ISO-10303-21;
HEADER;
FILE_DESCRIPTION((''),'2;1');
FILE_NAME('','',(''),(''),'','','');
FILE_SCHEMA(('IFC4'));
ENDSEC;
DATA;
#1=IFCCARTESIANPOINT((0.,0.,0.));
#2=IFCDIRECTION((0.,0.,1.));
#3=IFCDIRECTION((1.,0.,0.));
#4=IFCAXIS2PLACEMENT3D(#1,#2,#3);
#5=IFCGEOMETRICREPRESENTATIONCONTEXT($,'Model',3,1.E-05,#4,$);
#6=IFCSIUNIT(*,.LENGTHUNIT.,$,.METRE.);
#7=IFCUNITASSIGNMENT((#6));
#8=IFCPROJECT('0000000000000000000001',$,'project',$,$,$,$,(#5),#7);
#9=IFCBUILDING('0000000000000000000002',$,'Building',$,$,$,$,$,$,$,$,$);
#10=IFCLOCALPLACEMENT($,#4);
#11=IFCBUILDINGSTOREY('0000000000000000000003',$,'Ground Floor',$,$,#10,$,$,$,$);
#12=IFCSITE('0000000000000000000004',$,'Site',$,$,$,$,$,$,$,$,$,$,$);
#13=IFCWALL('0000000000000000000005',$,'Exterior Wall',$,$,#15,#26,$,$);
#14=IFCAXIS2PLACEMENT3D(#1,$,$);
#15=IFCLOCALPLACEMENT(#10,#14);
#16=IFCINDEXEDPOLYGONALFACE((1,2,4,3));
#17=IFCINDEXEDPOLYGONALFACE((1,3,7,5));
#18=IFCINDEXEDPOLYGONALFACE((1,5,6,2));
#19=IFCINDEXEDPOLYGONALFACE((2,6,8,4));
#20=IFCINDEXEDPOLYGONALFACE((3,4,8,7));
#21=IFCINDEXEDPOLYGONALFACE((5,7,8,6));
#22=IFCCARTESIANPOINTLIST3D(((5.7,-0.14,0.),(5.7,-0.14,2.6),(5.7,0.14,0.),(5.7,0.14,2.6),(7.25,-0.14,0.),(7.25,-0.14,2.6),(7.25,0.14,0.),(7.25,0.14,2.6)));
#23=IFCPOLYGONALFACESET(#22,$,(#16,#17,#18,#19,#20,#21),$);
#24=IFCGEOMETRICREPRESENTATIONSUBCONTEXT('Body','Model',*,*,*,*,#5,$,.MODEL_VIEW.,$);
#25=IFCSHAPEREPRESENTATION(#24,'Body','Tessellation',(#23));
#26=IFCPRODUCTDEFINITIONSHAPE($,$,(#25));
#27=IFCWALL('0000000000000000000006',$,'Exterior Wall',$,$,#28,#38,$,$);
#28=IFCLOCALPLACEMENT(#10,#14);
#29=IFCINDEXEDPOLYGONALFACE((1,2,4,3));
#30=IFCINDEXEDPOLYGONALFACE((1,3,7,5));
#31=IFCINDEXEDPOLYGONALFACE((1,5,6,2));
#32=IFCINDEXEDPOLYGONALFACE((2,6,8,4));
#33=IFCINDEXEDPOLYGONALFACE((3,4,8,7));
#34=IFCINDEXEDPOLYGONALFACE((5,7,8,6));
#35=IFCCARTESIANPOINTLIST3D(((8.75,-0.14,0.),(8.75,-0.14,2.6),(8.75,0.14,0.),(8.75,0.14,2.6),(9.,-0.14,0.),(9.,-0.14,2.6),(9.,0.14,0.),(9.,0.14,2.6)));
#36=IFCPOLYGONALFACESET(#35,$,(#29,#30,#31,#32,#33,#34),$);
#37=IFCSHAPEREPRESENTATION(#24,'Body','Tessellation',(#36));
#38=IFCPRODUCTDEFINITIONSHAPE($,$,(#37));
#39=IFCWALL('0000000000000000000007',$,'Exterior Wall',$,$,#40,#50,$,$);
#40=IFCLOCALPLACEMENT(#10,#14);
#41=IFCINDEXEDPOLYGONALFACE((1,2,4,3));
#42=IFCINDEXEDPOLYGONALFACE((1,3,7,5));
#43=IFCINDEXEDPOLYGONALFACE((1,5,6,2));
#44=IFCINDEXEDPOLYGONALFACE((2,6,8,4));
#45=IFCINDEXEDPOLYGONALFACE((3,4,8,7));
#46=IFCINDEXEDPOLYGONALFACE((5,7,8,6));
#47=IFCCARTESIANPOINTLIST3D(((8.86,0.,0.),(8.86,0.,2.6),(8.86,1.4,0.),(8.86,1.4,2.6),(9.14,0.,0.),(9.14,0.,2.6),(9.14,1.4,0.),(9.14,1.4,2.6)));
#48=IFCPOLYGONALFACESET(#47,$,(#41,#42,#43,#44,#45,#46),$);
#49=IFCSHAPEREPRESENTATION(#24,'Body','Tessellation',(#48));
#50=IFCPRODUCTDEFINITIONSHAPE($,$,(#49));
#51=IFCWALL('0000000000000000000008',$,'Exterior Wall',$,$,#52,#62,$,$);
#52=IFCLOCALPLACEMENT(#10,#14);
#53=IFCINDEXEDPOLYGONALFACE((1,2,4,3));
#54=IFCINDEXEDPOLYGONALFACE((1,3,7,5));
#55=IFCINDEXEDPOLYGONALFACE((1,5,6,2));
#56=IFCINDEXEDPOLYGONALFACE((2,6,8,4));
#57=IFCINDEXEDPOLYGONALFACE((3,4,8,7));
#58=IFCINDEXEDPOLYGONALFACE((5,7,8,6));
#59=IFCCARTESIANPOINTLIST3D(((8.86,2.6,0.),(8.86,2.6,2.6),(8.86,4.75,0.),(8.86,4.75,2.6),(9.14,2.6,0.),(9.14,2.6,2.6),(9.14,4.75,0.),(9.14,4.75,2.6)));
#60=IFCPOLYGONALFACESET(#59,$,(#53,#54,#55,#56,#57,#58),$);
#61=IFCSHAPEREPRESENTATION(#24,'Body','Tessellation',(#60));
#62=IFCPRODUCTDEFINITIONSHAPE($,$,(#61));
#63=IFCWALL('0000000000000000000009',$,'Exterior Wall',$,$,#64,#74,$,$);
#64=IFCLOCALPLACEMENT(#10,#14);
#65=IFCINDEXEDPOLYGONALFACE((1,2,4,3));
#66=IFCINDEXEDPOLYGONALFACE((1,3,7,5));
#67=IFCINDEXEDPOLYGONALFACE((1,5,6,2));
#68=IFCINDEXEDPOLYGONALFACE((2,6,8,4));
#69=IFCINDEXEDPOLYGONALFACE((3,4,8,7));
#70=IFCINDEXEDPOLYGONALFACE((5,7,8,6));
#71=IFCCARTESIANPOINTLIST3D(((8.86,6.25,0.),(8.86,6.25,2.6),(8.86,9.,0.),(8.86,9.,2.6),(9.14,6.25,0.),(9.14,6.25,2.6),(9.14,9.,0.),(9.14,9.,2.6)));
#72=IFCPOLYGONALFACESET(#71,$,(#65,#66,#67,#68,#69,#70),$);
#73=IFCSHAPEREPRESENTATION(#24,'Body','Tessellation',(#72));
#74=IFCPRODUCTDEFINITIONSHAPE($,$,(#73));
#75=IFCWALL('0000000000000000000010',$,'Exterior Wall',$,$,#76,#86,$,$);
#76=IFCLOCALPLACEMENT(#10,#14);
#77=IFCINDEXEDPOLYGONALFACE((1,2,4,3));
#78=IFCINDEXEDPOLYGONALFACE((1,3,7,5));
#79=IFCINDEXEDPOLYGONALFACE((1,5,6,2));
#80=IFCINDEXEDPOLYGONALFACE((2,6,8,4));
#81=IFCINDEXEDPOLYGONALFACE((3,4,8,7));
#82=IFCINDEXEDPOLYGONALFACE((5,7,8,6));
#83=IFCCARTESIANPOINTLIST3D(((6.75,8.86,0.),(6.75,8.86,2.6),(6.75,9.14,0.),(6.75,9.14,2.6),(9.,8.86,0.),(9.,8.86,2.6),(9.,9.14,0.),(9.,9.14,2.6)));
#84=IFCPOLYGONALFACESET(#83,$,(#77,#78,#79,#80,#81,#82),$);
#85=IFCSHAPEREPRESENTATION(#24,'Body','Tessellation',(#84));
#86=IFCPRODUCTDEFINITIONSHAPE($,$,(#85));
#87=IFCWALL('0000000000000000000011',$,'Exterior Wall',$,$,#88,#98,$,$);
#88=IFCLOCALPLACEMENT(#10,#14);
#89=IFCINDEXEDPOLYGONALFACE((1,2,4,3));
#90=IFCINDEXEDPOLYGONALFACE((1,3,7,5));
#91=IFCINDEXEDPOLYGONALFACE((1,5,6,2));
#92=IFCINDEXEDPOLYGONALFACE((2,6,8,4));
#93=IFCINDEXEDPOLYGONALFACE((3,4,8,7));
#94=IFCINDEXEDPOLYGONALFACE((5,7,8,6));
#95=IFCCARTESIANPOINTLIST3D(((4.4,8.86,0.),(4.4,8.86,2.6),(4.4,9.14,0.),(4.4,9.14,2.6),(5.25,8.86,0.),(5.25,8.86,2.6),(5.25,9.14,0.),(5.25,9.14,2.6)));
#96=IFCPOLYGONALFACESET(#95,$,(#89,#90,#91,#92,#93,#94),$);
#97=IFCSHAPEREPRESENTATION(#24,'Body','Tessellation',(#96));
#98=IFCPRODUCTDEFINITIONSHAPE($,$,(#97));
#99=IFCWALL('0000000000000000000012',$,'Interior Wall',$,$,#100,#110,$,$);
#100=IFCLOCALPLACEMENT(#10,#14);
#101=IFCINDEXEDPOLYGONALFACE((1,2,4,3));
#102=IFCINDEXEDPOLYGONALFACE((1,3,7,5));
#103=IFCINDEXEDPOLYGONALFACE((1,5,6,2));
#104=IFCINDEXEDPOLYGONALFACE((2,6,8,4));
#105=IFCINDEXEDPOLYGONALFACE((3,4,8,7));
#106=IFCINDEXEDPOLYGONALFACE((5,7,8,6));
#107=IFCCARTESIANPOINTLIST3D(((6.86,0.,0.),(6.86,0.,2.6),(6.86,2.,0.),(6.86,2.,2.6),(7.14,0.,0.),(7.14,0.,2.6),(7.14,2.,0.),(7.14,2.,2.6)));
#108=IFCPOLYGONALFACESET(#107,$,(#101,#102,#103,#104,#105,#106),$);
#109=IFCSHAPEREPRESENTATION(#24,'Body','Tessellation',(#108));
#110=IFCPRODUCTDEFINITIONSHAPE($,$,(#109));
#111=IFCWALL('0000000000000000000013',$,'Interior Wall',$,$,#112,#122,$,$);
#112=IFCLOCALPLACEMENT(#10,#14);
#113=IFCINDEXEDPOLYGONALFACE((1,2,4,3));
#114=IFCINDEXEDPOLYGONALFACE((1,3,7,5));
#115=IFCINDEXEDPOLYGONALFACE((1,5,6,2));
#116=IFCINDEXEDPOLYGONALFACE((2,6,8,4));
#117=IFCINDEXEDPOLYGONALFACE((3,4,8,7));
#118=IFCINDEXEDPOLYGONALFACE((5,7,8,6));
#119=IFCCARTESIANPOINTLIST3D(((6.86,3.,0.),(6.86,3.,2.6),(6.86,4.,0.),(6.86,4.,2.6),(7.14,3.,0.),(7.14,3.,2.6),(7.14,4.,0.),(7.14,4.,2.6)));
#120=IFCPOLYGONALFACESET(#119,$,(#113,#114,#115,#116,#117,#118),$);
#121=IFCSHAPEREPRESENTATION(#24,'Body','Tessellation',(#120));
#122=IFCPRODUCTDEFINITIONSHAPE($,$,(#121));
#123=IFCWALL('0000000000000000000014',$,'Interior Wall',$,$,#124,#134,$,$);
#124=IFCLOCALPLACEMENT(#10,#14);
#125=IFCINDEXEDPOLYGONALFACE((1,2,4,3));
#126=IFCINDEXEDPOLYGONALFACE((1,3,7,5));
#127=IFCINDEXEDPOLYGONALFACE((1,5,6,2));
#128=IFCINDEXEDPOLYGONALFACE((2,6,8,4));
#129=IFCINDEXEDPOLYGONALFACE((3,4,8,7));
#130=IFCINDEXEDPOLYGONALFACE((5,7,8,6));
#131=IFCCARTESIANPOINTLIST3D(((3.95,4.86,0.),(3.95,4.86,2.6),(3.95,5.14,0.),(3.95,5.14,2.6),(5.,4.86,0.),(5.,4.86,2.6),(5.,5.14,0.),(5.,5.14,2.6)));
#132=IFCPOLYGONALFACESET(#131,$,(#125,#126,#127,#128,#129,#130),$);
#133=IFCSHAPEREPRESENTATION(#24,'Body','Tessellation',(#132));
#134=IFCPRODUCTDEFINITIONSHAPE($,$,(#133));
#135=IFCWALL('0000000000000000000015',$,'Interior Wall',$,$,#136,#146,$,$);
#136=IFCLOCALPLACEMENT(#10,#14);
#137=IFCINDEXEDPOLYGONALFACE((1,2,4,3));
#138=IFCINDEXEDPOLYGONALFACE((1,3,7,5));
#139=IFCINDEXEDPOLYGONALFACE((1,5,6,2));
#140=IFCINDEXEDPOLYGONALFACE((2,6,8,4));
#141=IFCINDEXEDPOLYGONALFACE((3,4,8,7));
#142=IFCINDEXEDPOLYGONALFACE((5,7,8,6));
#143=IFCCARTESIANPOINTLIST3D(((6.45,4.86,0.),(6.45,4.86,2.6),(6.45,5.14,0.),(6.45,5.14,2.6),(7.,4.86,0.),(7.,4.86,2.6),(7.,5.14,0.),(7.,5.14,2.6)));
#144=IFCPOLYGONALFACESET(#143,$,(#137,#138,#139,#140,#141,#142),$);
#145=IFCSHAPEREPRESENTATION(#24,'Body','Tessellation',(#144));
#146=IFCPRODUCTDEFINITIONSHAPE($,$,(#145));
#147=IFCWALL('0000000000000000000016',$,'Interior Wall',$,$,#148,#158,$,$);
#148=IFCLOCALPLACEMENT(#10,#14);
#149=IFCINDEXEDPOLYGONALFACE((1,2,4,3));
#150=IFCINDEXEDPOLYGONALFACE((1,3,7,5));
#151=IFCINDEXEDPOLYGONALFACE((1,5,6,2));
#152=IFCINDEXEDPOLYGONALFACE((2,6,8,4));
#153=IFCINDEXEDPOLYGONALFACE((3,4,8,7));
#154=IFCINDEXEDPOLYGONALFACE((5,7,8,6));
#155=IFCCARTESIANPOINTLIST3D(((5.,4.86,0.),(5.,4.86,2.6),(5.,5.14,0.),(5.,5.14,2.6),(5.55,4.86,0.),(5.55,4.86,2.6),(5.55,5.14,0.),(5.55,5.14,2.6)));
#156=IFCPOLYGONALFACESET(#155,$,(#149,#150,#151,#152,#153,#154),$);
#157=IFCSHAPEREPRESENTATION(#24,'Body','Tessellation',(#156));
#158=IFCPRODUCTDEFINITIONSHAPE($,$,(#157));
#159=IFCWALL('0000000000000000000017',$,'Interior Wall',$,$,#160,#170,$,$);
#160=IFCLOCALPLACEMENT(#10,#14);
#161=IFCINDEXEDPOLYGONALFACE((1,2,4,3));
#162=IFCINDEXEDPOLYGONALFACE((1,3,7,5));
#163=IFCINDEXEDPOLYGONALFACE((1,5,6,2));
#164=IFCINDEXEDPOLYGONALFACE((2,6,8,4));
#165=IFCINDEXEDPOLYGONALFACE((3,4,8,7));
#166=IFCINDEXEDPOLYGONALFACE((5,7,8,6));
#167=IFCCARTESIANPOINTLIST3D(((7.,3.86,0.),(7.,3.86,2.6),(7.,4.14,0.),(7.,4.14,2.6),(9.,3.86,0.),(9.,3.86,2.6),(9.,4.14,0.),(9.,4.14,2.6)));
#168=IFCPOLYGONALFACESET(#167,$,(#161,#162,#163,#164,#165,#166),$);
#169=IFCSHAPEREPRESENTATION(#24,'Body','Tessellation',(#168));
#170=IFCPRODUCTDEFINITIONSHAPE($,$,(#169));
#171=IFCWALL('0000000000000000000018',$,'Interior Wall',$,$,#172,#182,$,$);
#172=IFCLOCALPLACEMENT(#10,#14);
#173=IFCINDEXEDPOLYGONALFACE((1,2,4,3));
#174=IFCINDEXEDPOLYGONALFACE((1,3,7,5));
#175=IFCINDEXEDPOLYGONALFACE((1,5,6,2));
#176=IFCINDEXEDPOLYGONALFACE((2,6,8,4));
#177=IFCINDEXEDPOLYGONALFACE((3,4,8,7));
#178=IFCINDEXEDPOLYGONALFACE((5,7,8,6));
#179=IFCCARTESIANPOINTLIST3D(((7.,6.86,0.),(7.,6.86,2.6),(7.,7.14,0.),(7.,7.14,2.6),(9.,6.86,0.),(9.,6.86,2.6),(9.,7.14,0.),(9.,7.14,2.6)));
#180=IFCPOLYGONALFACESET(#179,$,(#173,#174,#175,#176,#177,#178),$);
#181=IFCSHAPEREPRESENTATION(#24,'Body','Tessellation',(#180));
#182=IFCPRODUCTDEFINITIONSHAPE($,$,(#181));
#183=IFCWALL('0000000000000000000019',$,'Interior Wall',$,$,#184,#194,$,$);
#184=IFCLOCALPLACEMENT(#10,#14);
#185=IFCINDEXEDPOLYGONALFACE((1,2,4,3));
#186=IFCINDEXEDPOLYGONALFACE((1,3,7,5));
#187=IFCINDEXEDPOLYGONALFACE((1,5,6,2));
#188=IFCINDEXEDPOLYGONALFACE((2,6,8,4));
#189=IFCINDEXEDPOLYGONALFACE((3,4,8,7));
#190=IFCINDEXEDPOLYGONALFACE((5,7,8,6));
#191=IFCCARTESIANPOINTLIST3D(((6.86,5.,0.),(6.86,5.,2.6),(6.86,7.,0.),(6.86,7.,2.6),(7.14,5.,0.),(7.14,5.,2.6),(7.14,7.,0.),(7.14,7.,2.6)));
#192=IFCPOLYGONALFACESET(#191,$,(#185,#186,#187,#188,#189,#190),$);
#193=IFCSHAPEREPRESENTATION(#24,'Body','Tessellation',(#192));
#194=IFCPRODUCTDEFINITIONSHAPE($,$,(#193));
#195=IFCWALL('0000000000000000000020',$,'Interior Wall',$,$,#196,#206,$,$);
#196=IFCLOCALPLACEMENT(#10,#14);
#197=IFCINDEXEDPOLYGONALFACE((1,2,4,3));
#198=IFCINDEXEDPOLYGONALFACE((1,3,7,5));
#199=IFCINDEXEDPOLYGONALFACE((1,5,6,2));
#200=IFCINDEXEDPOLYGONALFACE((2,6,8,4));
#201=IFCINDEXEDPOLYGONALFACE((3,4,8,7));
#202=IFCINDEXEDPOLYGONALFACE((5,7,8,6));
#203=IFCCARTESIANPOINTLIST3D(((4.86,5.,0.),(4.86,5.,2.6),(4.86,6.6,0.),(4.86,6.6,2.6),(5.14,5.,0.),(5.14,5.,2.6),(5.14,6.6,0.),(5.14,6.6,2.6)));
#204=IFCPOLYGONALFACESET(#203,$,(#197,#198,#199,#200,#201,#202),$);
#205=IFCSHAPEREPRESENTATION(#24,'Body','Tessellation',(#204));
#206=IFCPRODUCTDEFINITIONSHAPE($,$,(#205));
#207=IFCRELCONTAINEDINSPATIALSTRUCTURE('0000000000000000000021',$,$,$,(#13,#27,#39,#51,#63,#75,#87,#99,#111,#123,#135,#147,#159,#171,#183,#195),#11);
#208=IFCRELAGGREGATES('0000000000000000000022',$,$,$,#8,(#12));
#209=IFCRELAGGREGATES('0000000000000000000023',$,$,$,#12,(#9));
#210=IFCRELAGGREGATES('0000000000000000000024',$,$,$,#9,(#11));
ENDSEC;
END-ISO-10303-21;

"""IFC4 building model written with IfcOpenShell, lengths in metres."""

from ifc_helpers import new_model, si_unit, frame, origin_with_axes, place, context, subcontext, project, spatial, indexed_curve, outline, extrude, element, save


model = new_model("IFC4")

# Units and contexts
model_context = context("Model", 3, precision=1e-05, world=origin_with_axes())
body_context = subcontext(model_context, "Body", "Model", "MODEL_VIEW")
ifc_project = project(units=[si_unit("LENGTHUNIT", "METRE")], contexts=[model_context])

# Site, building, storey
site = spatial("IfcSite", under=ifc_project, Name="Site")
building = spatial("IfcBuilding", under=site, Name="Building")
storey_placement = place(None, origin_with_axes())
storey = spatial("IfcBuildingStorey", under=building, at=storey_placement, Name="Ground Floor")

# Walls
wall_1_placement = place(storey_placement, frame((5.7, 0.0, 0.0), z_axis=(0.0, 0.0, 1.0), x_axis=(1.0, 0.0, 0.0)))
element("IfcWall", 1, at=wall_1_placement, inside=storey, Name="Exterior Wall", context=body_context, shape_type="SweptSolid", body=[
    extrude(outline(indexed_curve([(0.0, 0.0), (0.0, 0.28), (1.55, 0.28), (1.55, 0.0), (0.0, 0.0)], self_intersect=False)), frame((0.0, -0.14, 0.0), z_axis=(0.0, 0.0, 1.0), x_axis=(1.0, 0.0, 0.0)), (0.0, 0.0, 1.0), 2.6),
])
wall_2_placement = place(storey_placement, frame((8.75, 0.0, 0.0), z_axis=(0.0, 0.0, 1.0), x_axis=(1.0, 0.0, 0.0)))
element("IfcWall", 2, at=wall_2_placement, inside=storey, Name="Exterior Wall", context=body_context, shape_type="SweptSolid", body=[
    extrude(outline(indexed_curve([(0.0, 0.0), (0.0, 0.28), (0.25, 0.28), (0.25, 0.0), (0.0, 0.0)], self_intersect=False)), frame((0.0, -0.14, 0.0), z_axis=(0.0, 0.0, 1.0), x_axis=(1.0, 0.0, 0.0)), (0.0, 0.0, 1.0), 2.6),
])
wall_3_placement = place(storey_placement, frame((9.0, 0.0, 0.0), z_axis=(0.0, 0.0, 1.0), x_axis=(0.0, 1.0, 0.0)))
element("IfcWall", 3, at=wall_3_placement, inside=storey, Name="Exterior Wall", context=body_context, shape_type="SweptSolid", body=[
    extrude(outline(indexed_curve([(0.0, 0.0), (0.0, 0.28), (1.4, 0.28), (1.4, 0.0), (0.0, 0.0)], self_intersect=False)), frame((0.0, -0.14, 0.0), z_axis=(0.0, 0.0, 1.0), x_axis=(1.0, 0.0, 0.0)), (0.0, 0.0, 1.0), 2.6),
])
wall_4_placement = place(storey_placement, frame((9.0, 2.6, 0.0), z_axis=(0.0, 0.0, 1.0), x_axis=(0.0, 1.0, 0.0)))
element("IfcWall", 4, at=wall_4_placement, inside=storey, Name="Exterior Wall", context=body_context, shape_type="SweptSolid", body=[
    extrude(outline(indexed_curve([(0.0, 0.0), (0.0, 0.28), (2.15, 0.28), (2.15, 0.0), (0.0, 0.0)], self_intersect=False)), frame((0.0, -0.14, 0.0), z_axis=(0.0, 0.0, 1.0), x_axis=(1.0, 0.0, 0.0)), (0.0, 0.0, 1.0), 2.6),
])
wall_5_placement = place(storey_placement, frame((9.0, 6.25, 0.0), z_axis=(0.0, 0.0, 1.0), x_axis=(0.0, 1.0, 0.0)))
element("IfcWall", 5, at=wall_5_placement, inside=storey, Name="Exterior Wall", context=body_context, shape_type="SweptSolid", body=[
    extrude(outline(indexed_curve([(0.0, 0.0), (0.0, 0.28), (2.75, 0.28), (2.75, 0.0), (0.0, 0.0)], self_intersect=False)), frame((0.0, -0.14, 0.0), z_axis=(0.0, 0.0, 1.0), x_axis=(1.0, 0.0, 0.0)), (0.0, 0.0, 1.0), 2.6),
])
wall_6_placement = place(storey_placement, frame((9.0, 9.0, 0.0), z_axis=(0.0, 0.0, 1.0), x_axis=(-1.0, 0.0, 0.0)))
element("IfcWall", 6, at=wall_6_placement, inside=storey, Name="Exterior Wall", context=body_context, shape_type="SweptSolid", body=[
    extrude(outline(indexed_curve([(0.0, 0.0), (0.0, 0.28), (2.25, 0.28), (2.25, 0.0), (0.0, 0.0)], self_intersect=False)), frame((0.0, -0.14, 0.0), z_axis=(0.0, 0.0, 1.0), x_axis=(1.0, 0.0, 0.0)), (0.0, 0.0, 1.0), 2.6),
])
wall_7_placement = place(storey_placement, frame((5.25, 9.0, 0.0), z_axis=(0.0, 0.0, 1.0), x_axis=(-1.0, 0.0, 0.0)))
element("IfcWall", 7, at=wall_7_placement, inside=storey, Name="Exterior Wall", context=body_context, shape_type="SweptSolid", body=[
    extrude(outline(indexed_curve([(0.0, 0.0), (0.0, 0.28), (0.85, 0.28), (0.85, 0.0), (0.0, 0.0)], self_intersect=False)), frame((0.0, -0.14, 0.0), z_axis=(0.0, 0.0, 1.0), x_axis=(1.0, 0.0, 0.0)), (0.0, 0.0, 1.0), 2.6),
])
wall_8_placement = place(storey_placement, frame((7.0, 0.0, 0.0), z_axis=(0.0, 0.0, 1.0), x_axis=(0.0, 1.0, 0.0)))
element("IfcWall", 8, at=wall_8_placement, inside=storey, Name="Interior Wall", context=body_context, shape_type="SweptSolid", body=[
    extrude(outline(indexed_curve([(0.0, 0.0), (0.0, 0.28), (2.0, 0.28), (2.0, 0.0), (0.0, 0.0)], self_intersect=False)), frame((0.0, -0.14, 0.0), z_axis=(0.0, 0.0, 1.0), x_axis=(1.0, 0.0, 0.0)), (0.0, 0.0, 1.0), 2.6),
])
wall_9_placement = place(storey_placement, frame((7.0, 3.0, 0.0), z_axis=(0.0, 0.0, 1.0), x_axis=(0.0, 1.0, 0.0)))
element("IfcWall", 9, at=wall_9_placement, inside=storey, Name="Interior Wall", context=body_context, shape_type="SweptSolid", body=[
    extrude(outline(indexed_curve([(0.0, 0.0), (0.0, 0.28), (1.0, 0.28), (1.0, 0.0), (0.0, 0.0)], self_intersect=False)), frame((0.0, -0.14, 0.0), z_axis=(0.0, 0.0, 1.0), x_axis=(1.0, 0.0, 0.0)), (0.0, 0.0, 1.0), 2.6),
])
wall_10_placement = place(storey_placement, frame((5.0, 5.0, 0.0), z_axis=(0.0, 0.0, 1.0), x_axis=(-1.0, 0.0, 0.0)))
element("IfcWall", 10, at=wall_10_placement, inside=storey, Name="Interior Wall", context=body_context, shape_type="SweptSolid", body=[
    extrude(outline(indexed_curve([(0.0, 0.0), (0.0, 0.28), (1.05, 0.28), (1.05, 0.0), (0.0, 0.0)], self_intersect=False)), frame((0.0, -0.14, 0.0), z_axis=(0.0, 0.0, 1.0), x_axis=(1.0, 0.0, 0.0)), (0.0, 0.0, 1.0), 2.6),
])
for number, where, z_axis, x_axis, name in (
    (11, (7.0, 5.0, 0.0), (0.0, 0.0, 1.0), (-1.0, 0.0, 0.0), "Interior Wall"),
    (12, (5.55, 5.0, 0.0), (0.0, 0.0, 1.0), (-1.0, 0.0, 0.0), "Interior Wall"),
):
    element("IfcWall", number, at=place(storey_placement, frame(where, z_axis=z_axis, x_axis=x_axis)), inside=storey, Name=name, context=body_context, shape_type="SweptSolid", body=[
        extrude(outline(indexed_curve([(0.0, 0.0), (0.0, 0.28), (0.55, 0.28), (0.55, 0.0), (0.0, 0.0)], self_intersect=False)), frame((0.0, -0.14, 0.0), z_axis=(0.0, 0.0, 1.0), x_axis=(1.0, 0.0, 0.0)), (0.0, 0.0, 1.0), 2.6),
    ])
for number, where, z_axis, x_axis, name in (
    (13, (9.0, 4.0, 0.0), (0.0, 0.0, 1.0), (-1.0, 0.0, 0.0), "Interior Wall"),
    (14, (9.0, 7.0, 0.0), (0.0, 0.0, 1.0), (-1.0, 0.0, 0.0), "Interior Wall"),
    (15, (7.0, 7.0, 0.0), (0.0, 0.0, 1.0), (0.0, -1.0, 0.0), "Interior Wall"),
):
    element("IfcWall", number, at=place(storey_placement, frame(where, z_axis=z_axis, x_axis=x_axis)), inside=storey, Name=name, context=body_context, shape_type="SweptSolid", body=[
        extrude(outline(indexed_curve([(0.0, 0.0), (0.0, 0.28), (2.0, 0.28), (2.0, 0.0), (0.0, 0.0)], self_intersect=False)), frame((0.0, -0.14, 0.0), z_axis=(0.0, 0.0, 1.0), x_axis=(1.0, 0.0, 0.0)), (0.0, 0.0, 1.0), 2.6),
    ])
for number, where, z_axis, x_axis, name in (
    (16, (5.0, 5.0, 0.0), (0.0, 0.0, 1.0), (0.0, 1.0, 0.0), "Interior Wall"),
):
    element("IfcWall", number, at=place(storey_placement, frame(where, z_axis=z_axis, x_axis=x_axis)), inside=storey, Name=name, context=body_context, shape_type="SweptSolid", body=[
        extrude(outline(indexed_curve([(0.0, 0.0), (0.0, 0.28), (1.6, 0.28), (1.6, 0.0), (0.0, 0.0)], self_intersect=False)), frame((0.0, -0.14, 0.0), z_axis=(0.0, 0.0, 1.0), x_axis=(1.0, 0.0, 0.0)), (0.0, 0.0, 1.0), 2.6),
    ])

save(model, "model.ifc")
